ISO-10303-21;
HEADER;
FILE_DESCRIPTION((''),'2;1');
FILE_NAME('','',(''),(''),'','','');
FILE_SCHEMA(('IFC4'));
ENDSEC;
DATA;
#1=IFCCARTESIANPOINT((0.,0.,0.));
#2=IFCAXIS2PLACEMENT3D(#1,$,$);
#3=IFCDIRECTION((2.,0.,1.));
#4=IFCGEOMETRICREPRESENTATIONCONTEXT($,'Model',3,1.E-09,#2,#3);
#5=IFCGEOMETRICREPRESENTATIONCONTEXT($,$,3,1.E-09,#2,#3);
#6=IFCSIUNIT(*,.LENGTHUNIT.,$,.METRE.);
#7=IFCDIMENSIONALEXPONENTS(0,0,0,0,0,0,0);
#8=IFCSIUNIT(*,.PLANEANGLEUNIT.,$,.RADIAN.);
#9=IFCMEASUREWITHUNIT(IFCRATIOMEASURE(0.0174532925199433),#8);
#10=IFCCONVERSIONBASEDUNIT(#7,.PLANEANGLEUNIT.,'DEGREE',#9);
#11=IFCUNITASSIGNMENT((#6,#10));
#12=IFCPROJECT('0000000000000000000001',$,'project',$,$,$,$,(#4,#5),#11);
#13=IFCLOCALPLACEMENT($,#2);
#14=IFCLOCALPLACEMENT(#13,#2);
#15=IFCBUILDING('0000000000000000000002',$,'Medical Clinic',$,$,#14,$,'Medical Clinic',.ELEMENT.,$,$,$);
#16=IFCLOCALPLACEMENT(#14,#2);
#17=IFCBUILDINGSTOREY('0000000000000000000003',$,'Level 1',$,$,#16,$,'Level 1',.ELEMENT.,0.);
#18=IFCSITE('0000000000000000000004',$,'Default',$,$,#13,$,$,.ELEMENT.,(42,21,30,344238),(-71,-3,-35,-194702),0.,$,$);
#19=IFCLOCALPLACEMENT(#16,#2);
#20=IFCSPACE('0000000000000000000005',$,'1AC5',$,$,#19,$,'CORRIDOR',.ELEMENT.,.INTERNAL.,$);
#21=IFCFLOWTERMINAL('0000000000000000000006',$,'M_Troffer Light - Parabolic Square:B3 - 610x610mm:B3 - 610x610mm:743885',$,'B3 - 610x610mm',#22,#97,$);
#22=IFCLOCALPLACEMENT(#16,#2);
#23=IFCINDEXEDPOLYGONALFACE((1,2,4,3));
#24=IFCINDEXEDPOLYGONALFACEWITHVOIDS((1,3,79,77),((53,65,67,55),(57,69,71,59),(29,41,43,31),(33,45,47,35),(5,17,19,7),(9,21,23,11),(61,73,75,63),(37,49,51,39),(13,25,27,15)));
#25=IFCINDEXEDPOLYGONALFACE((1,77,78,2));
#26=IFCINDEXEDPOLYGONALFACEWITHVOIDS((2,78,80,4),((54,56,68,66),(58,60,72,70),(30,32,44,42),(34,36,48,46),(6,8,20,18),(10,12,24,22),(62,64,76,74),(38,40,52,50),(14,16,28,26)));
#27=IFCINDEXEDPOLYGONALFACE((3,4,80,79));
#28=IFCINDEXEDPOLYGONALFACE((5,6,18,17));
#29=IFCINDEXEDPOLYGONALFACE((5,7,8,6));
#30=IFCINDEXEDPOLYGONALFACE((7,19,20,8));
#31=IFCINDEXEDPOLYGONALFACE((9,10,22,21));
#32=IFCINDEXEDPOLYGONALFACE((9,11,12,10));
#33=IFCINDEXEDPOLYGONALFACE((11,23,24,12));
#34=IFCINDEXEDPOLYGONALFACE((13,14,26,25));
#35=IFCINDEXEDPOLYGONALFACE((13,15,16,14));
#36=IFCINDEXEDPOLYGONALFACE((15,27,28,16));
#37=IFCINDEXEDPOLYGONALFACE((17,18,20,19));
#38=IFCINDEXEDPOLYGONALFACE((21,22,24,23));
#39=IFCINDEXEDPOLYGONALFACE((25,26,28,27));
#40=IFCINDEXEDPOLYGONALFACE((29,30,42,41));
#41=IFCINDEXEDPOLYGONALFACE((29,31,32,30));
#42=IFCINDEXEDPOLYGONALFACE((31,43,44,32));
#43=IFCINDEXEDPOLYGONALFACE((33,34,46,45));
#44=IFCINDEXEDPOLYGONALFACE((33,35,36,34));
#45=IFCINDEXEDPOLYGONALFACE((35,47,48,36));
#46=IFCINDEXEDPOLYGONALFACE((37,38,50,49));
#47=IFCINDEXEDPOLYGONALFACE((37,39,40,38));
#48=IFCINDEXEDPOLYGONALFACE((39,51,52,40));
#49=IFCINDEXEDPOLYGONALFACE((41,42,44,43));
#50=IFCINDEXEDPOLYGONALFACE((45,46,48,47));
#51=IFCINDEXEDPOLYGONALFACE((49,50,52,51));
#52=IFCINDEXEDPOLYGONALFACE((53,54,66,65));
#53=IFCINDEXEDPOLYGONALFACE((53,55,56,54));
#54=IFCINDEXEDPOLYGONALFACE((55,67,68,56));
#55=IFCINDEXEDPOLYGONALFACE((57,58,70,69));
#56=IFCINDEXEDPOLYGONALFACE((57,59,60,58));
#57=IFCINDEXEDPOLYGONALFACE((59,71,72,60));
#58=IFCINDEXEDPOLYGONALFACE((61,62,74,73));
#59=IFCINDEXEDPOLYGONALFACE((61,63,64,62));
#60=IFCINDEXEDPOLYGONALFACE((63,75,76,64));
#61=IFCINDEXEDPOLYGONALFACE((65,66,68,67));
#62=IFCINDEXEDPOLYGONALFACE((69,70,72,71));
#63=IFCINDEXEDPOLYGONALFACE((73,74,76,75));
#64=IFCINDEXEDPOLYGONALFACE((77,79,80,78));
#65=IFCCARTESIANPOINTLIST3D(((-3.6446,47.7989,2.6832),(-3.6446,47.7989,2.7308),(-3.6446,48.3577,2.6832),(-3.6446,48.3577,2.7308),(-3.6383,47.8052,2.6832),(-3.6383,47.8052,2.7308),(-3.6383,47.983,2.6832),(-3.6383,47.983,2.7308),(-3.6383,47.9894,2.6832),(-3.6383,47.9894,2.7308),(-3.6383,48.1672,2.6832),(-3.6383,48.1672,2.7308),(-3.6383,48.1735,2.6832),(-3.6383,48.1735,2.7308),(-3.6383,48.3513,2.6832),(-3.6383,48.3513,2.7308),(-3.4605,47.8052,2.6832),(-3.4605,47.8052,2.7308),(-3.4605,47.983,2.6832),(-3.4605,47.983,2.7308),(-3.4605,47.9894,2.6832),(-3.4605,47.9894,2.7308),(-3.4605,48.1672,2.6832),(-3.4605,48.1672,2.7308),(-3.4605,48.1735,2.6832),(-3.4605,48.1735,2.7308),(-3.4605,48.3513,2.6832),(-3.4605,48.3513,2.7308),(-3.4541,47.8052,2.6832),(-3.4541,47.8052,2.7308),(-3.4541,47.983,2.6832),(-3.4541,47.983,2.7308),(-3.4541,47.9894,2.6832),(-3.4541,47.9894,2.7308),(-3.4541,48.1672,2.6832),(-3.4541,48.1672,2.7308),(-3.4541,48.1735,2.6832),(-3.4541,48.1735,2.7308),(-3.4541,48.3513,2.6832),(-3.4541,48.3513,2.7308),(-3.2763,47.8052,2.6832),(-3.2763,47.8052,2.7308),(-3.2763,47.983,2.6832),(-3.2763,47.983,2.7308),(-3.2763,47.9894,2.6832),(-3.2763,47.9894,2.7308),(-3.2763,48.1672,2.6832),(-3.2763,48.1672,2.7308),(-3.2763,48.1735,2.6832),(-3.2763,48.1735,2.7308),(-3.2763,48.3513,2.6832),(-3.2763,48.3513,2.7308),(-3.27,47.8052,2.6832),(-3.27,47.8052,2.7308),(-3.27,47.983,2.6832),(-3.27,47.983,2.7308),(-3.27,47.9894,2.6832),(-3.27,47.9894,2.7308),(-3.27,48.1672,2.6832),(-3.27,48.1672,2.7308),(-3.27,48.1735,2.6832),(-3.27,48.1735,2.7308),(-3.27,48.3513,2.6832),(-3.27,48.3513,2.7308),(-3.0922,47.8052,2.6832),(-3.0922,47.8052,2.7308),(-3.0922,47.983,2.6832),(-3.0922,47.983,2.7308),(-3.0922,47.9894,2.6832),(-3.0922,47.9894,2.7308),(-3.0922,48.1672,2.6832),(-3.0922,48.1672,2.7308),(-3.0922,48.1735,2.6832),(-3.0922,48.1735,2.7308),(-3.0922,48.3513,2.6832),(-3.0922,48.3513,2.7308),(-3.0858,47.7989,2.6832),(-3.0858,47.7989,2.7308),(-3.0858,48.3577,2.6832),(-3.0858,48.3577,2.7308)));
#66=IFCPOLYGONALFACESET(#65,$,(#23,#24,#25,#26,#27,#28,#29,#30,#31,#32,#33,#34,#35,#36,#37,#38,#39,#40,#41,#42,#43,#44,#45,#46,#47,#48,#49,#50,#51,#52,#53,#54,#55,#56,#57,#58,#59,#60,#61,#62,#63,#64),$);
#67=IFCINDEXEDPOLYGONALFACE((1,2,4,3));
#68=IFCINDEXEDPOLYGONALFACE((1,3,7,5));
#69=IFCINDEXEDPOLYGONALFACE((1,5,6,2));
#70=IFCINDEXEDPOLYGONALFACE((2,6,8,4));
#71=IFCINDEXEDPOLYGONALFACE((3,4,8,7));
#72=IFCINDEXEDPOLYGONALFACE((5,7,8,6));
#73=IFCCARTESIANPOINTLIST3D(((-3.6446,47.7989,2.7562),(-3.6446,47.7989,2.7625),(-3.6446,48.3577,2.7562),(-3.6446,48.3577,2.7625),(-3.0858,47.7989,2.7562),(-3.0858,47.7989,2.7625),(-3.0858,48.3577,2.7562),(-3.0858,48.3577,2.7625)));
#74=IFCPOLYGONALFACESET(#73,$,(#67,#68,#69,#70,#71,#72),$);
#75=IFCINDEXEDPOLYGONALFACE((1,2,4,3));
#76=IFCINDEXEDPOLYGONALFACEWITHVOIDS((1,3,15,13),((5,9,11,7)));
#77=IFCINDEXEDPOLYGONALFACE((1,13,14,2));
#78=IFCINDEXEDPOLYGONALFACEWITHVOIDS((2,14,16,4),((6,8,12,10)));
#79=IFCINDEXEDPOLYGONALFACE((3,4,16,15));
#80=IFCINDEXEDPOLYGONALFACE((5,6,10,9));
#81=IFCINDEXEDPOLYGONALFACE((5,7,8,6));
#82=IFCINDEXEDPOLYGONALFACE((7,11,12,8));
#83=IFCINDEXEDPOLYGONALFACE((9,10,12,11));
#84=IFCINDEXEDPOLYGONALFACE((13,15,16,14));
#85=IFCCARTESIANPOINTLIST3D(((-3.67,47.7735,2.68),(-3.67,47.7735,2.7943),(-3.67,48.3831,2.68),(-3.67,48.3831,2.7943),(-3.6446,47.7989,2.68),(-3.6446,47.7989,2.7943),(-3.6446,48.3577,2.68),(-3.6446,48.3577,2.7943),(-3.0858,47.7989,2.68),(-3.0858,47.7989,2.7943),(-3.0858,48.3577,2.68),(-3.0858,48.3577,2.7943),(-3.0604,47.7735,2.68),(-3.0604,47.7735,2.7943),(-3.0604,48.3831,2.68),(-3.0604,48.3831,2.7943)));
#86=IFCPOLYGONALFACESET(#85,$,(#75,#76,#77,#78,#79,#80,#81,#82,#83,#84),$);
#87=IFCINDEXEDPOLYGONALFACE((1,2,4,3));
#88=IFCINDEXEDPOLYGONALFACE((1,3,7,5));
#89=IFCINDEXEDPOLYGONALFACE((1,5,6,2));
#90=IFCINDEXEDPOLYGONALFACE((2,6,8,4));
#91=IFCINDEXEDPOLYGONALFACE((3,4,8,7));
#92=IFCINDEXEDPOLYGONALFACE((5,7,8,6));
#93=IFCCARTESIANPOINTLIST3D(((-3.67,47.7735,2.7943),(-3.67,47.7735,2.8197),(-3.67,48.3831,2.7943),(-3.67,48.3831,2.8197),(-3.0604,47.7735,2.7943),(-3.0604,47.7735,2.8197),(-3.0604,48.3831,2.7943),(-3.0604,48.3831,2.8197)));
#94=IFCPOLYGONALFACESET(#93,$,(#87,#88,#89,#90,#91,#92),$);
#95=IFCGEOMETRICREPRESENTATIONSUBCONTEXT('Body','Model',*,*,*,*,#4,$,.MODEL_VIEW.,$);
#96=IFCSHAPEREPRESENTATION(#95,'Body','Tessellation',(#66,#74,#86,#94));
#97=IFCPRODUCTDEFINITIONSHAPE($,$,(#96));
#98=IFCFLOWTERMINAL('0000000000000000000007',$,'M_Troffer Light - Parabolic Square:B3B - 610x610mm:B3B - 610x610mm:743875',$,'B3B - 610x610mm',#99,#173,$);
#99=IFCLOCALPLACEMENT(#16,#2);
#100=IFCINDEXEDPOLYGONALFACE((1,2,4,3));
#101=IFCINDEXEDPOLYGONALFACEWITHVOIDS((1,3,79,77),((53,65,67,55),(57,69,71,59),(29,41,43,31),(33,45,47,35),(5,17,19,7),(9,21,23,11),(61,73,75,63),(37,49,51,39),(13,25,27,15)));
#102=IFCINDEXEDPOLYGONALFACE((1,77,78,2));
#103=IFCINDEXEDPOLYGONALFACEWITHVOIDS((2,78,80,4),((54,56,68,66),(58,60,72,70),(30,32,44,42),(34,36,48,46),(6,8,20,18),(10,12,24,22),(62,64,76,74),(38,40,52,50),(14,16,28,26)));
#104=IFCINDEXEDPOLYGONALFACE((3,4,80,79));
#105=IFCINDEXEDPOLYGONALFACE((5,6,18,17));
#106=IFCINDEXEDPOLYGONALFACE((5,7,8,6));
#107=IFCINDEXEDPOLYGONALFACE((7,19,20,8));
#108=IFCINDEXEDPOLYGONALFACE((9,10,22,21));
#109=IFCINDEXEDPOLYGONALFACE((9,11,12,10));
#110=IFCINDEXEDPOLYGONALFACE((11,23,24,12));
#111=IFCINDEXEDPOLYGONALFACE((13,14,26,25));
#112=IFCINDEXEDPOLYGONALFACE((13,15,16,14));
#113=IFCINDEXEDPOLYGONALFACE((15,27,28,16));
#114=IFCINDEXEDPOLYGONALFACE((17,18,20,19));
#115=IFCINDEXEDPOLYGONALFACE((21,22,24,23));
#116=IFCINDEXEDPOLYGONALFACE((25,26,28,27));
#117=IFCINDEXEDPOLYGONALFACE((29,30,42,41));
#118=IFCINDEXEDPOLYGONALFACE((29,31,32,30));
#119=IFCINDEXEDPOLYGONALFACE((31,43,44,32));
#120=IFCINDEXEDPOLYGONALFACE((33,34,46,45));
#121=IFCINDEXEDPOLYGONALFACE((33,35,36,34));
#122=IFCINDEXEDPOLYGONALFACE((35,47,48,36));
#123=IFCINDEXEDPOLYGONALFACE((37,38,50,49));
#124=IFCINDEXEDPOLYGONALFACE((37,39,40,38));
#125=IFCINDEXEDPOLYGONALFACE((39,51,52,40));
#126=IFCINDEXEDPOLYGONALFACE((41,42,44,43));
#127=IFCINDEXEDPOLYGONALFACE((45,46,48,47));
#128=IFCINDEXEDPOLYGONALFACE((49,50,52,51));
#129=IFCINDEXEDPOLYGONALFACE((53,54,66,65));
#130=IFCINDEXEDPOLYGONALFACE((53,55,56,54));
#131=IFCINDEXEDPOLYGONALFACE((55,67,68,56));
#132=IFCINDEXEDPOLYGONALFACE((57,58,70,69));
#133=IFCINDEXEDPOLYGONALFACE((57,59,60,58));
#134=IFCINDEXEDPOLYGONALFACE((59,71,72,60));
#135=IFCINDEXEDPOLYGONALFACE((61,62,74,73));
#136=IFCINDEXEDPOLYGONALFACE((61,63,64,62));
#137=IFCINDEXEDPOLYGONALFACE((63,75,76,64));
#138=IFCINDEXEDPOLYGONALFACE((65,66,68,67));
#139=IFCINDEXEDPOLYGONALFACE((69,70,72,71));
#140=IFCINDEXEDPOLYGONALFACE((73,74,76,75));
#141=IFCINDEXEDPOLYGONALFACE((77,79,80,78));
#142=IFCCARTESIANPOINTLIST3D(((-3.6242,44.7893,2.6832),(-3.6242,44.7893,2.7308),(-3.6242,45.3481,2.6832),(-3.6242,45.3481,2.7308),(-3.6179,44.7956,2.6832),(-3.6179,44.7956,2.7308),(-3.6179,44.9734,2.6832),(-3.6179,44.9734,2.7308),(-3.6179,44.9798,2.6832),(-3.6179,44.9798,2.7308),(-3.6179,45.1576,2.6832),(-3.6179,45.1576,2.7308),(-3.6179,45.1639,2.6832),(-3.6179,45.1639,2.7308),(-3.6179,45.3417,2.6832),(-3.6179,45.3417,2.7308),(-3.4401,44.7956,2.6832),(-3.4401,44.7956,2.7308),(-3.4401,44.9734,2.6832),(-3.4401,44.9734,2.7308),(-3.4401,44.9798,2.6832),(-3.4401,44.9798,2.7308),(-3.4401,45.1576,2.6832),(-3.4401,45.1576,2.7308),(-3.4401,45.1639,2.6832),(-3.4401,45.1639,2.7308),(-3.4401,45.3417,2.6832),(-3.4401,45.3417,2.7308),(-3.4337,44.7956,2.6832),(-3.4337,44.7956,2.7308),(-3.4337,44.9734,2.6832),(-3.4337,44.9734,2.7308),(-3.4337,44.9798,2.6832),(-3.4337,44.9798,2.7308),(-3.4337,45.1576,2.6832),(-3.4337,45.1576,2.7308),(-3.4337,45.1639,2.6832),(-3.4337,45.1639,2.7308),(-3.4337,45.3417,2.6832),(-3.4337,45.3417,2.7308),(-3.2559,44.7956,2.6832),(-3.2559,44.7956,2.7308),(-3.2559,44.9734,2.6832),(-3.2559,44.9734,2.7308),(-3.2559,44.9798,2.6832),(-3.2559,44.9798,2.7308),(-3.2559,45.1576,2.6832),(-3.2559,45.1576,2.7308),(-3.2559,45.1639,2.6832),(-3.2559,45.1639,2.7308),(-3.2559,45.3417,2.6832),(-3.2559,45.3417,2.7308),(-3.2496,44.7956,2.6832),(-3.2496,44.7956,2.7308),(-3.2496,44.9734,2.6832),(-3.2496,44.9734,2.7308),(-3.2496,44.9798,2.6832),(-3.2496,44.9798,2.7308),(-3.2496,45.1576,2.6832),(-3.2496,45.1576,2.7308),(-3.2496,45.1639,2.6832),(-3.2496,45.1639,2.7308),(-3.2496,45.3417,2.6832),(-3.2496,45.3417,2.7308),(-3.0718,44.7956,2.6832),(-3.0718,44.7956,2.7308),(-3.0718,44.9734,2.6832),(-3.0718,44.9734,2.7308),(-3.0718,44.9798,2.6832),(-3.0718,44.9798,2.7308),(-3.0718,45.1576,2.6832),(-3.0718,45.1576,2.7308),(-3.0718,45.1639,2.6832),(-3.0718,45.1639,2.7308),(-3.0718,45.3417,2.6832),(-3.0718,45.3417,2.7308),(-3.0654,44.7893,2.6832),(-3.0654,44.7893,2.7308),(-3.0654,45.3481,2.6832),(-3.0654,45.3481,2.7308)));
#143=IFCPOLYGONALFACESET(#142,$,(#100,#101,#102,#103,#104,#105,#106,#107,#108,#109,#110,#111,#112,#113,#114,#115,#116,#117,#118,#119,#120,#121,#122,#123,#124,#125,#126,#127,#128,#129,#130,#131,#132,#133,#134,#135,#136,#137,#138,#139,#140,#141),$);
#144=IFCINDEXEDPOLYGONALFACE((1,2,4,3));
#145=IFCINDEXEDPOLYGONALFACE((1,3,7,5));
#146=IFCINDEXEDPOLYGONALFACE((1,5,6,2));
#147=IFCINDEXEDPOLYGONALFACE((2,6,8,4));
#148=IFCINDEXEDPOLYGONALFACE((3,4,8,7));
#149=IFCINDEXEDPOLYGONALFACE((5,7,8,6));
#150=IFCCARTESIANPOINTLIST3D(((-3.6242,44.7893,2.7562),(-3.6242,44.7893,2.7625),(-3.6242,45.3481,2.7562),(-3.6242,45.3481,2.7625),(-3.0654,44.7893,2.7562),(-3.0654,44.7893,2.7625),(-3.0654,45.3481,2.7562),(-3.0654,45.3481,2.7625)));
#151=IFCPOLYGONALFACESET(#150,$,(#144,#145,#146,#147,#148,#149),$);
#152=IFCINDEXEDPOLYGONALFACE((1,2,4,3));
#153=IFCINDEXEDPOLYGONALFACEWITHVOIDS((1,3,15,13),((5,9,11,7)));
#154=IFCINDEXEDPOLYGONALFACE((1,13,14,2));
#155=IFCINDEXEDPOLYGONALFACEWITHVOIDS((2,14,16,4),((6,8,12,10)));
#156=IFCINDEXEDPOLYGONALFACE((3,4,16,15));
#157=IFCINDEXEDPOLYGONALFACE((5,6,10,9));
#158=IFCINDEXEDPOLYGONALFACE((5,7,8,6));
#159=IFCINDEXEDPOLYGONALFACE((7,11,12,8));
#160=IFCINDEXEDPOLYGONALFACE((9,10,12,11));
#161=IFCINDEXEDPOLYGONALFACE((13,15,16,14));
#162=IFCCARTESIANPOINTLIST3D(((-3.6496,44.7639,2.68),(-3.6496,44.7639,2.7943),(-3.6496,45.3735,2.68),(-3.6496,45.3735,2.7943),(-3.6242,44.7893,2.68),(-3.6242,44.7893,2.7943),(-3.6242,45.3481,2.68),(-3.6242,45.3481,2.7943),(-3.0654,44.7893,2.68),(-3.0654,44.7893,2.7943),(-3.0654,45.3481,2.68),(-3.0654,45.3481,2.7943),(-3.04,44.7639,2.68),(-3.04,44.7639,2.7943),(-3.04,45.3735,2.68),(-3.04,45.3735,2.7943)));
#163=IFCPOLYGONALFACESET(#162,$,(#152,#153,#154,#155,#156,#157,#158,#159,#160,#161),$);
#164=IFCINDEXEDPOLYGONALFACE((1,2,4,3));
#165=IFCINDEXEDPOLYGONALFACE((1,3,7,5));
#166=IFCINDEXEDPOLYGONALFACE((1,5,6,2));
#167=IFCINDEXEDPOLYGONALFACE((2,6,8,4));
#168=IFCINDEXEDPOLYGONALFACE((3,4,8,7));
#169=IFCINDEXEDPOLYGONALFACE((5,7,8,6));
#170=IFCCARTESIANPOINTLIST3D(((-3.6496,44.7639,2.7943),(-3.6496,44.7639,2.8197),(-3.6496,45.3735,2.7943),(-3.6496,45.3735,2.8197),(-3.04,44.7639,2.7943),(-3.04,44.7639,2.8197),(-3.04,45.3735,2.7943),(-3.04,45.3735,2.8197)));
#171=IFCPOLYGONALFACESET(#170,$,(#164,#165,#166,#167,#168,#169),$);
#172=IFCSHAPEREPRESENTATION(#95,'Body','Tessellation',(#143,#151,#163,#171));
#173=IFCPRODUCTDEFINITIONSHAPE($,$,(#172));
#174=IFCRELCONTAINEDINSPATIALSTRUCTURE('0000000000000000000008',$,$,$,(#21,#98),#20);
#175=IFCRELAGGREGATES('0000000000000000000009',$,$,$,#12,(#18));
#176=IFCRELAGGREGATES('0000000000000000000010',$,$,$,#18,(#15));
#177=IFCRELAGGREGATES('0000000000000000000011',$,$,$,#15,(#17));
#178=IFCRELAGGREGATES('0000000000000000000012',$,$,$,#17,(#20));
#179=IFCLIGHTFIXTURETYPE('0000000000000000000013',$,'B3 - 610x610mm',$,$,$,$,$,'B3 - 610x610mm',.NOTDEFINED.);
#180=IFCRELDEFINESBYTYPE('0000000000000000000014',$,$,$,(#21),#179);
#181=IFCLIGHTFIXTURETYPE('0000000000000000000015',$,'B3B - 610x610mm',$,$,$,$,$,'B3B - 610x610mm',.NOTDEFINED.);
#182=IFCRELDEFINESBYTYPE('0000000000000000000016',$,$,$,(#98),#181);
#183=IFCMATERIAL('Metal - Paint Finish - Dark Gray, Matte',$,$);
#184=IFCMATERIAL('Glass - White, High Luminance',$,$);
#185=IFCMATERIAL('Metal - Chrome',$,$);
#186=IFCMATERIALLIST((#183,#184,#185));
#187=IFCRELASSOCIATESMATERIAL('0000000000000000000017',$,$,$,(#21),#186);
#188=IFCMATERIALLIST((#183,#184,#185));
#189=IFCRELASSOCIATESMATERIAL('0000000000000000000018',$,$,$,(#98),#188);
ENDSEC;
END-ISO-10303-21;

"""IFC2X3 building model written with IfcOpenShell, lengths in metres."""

from ifc_helpers import new_model, entity, si_unit, converted_unit, direction, frame, origin, origin_2d_with_axis, place, context, subcontext, project, spatial, polyline, rectangle, outline, extrude, source, transform, mapped, material, material_list, type_object, type_shapes, element, save


model = new_model("IFC2X3")

# Units and contexts
model_context = context("Model", 3, precision=1e-09, world=origin(), true_north=direction((2.0, 0.0, 1.0)))
context_of_model = context(None, 3, precision=1e-09, world=origin(), true_north=direction((2.0, 0.0, 1.0)))
body_context = subcontext(model_context, "Body", "Model", "MODEL_VIEW")
ifc_project = project(units=[si_unit("LENGTHUNIT", "METRE"), converted_unit("PLANEANGLEUNIT", "DEGREE", entity("IfcRatioMeasure", 0.0174532925199433), si_unit("PLANEANGLEUNIT", "RADIAN"), dimensions=[0, 0, 0, 0, 0, 0, 0])], contexts=[model_context, context_of_model])

# Site, building, storey, space
site_placement = place(None, origin())
site = spatial("IfcSite", under=ifc_project, at=site_placement, Name="Default", CompositionType="ELEMENT", RefLatitude=(42, 21, 30, 344238), RefLongitude=(-71, -3, -35, -194702), RefElevation=0.0)
building_placement = place(site_placement, origin())
building = spatial("IfcBuilding", under=site, at=building_placement, Name="Medical Clinic", LongName="Medical Clinic", CompositionType="ELEMENT")
storey_placement = place(building_placement, origin())
storey = spatial("IfcBuildingStorey", under=building, at=storey_placement, Name="Level 1", LongName="Level 1", CompositionType="ELEMENT", Elevation=0.0)
space_1_placement = place(storey_placement, origin())
space_1 = spatial("IfcSpace", under=storey, at=space_1_placement, Name="1AC5", LongName="CORRIDOR", CompositionType="ELEMENT", InteriorOrExteriorSpace="INTERNAL")

# Flow terminals
ifc_material_1 = material(Name="Metal - Paint Finish - Dark Gray, Matte")
ifc_material_2 = material(Name="Glass - White, High Luminance")
ifc_material_3 = material(Name="Metal - Chrome")
ifc_material_list_1 = material_list([ifc_material_1, ifc_material_2, ifc_material_3])
light_fixture_type_1 = type_object("IfcLightFixtureType", Name="B3 - 610x610mm", ElementType="B3 - 610x610mm", PredefinedType="NOTDEFINED")
shared_shape_1 = source(origin(), body_context, "Body", "SweptSolid", [
    extrude(outline(polyline([(-0.2794, -0.2794), (0.2794, -0.2794), (0.2794, 0.2794), (-0.2794, 0.2794), (-0.2794, -0.2794)]), holes=[polyline([(-0.0952, 0.0953), (-0.273, 0.0953), (-0.273, 0.2731), (-0.0952, 0.2731), (-0.0952, 0.0953)]), polyline([(0.2731, 0.0953), (0.0953, 0.0953), (0.0953, 0.2731), (0.2731, 0.2731), (0.2731, 0.0953)]), polyline([(-0.0889, 0.2731), (0.0889, 0.2731), (0.0889, 0.0953), (-0.0889, 0.0953), (-0.0889, 0.2731)]), polyline([(0.2731, -0.273), (0.0953, -0.273), (0.0953, -0.0952), (0.2731, -0.0952), (0.2731, -0.273)]), polyline([(0.0889, -0.273), (-0.0889, -0.273), (-0.0889, -0.0952), (0.0889, -0.0952), (0.0889, -0.273)]), polyline([(-0.0952, -0.273), (-0.273, -0.273), (-0.273, -0.0952), (-0.0952, -0.0952), (-0.0952, -0.273)]), polyline([(-0.0952, -0.0889), (-0.273, -0.0889), (-0.273, 0.0889), (-0.0952, 0.0889), (-0.0952, -0.0889)]), polyline([(0.0889, -0.0889), (-0.0889, -0.0889), (-0.0889, 0.0889), (0.0889, 0.0889), (0.0889, -0.0889)]), polyline([(0.2731, -0.0889), (0.0953, -0.0889), (0.0953, 0.0889), (0.2731, 0.0889), (0.2731, -0.0889)])]), frame((0.0, -0.3048, -0.0508), z_axis=(0.0, 0.0, 1.0), x_axis=(-1.0, 0.0, 0.0)), (0.0, 0.0, 1.0), 0.0476),
    extrude(rectangle(XDim=0.5588, YDim=0.5588, at=origin_2d_with_axis()), frame((0.0, -0.3048, -0.0825), z_axis=(0.0, 0.0, 1.0), x_axis=(-1.0, 0.0, 0.0)), (0.0, 0.0, 1.0), 0.0064),
    extrude(outline(polyline([(-0.3048, -0.3048), (0.3048, -0.3048), (0.3048, 0.3048), (-0.3048, 0.3048), (-0.3048, -0.3048)]), holes=[polyline([(0.2794, 0.2794), (0.2794, -0.2794), (-0.2794, -0.2794), (-0.2794, 0.2794), (0.2794, 0.2794)])]), frame((0.0, -0.3048, -0.1143)), (0.0, 0.0, 1.0), 0.1143),
    extrude(rectangle(XDim=0.6096, YDim=0.6096, at=origin_2d_with_axis()), frame((0.0, -0.3048, -0.1397), z_axis=(0.0, 0.0, 1.0), x_axis=(-1.0, 0.0, 0.0)), (0.0, 0.0, 1.0), 0.0254),
])
type_shapes(light_fixture_type_1, [shared_shape_1])
flow_terminal_1_placement = place(space_1_placement, frame((-3.3652, 47.7735, 2.68), z_axis=(0.0, 0.0, -1.0), x_axis=(1.0, 0.0, 0.0)))
element("IfcFlowTerminal", 1, at=flow_terminal_1_placement, inside=space_1, type_object=light_fixture_type_1, material=ifc_material_list_1, Name="M_Troffer Light - Parabolic Square:B3 - 610x610mm:B3 - 610x610mm:743885", ObjectType="B3 - 610x610mm", context=body_context, shape_type="MappedRepresentation", body=[
    mapped(shared_shape_1, transform((0.0, 0.0, 0.0), scale=1.0)),
])
ifc_material_list_2 = material_list([ifc_material_1, ifc_material_2, ifc_material_3])
light_fixture_type_2 = type_object("IfcLightFixtureType", Name="B3B - 610x610mm", ElementType="B3B - 610x610mm", PredefinedType="NOTDEFINED")
shared_shape_2 = source(origin(), body_context, "Body", "SweptSolid", [
    extrude(outline(polyline([(-0.2794, -0.2794), (0.2794, -0.2794), (0.2794, 0.2794), (-0.2794, 0.2794), (-0.2794, -0.2794)]), holes=[polyline([(-0.0952, 0.0953), (-0.273, 0.0953), (-0.273, 0.2731), (-0.0952, 0.2731), (-0.0952, 0.0953)]), polyline([(0.2731, 0.0953), (0.0953, 0.0953), (0.0953, 0.2731), (0.2731, 0.2731), (0.2731, 0.0953)]), polyline([(-0.0889, 0.2731), (0.0889, 0.2731), (0.0889, 0.0953), (-0.0889, 0.0953), (-0.0889, 0.2731)]), polyline([(0.2731, -0.273), (0.0953, -0.273), (0.0953, -0.0952), (0.2731, -0.0952), (0.2731, -0.273)]), polyline([(0.0889, -0.273), (-0.0889, -0.273), (-0.0889, -0.0952), (0.0889, -0.0952), (0.0889, -0.273)]), polyline([(-0.0952, -0.273), (-0.273, -0.273), (-0.273, -0.0952), (-0.0952, -0.0952), (-0.0952, -0.273)]), polyline([(-0.0952, -0.0889), (-0.273, -0.0889), (-0.273, 0.0889), (-0.0952, 0.0889), (-0.0952, -0.0889)]), polyline([(0.0889, -0.0889), (-0.0889, -0.0889), (-0.0889, 0.0889), (0.0889, 0.0889), (0.0889, -0.0889)]), polyline([(0.2731, -0.0889), (0.0953, -0.0889), (0.0953, 0.0889), (0.2731, 0.0889), (0.2731, -0.0889)])]), frame((0.0, -0.3048, -0.0508), z_axis=(0.0, 0.0, 1.0), x_axis=(-1.0, 0.0, 0.0)), (0.0, 0.0, 1.0), 0.0476),
    extrude(rectangle(XDim=0.5588, YDim=0.5588, at=origin_2d_with_axis()), frame((0.0, -0.3048, -0.0825), z_axis=(0.0, 0.0, 1.0), x_axis=(-1.0, 0.0, 0.0)), (0.0, 0.0, 1.0), 0.0064),
    extrude(outline(polyline([(-0.3048, -0.3048), (0.3048, -0.3048), (0.3048, 0.3048), (-0.3048, 0.3048), (-0.3048, -0.3048)]), holes=[polyline([(0.2794, 0.2794), (0.2794, -0.2794), (-0.2794, -0.2794), (-0.2794, 0.2794), (0.2794, 0.2794)])]), frame((0.0, -0.3048, -0.1143)), (0.0, 0.0, 1.0), 0.1143),
    extrude(rectangle(XDim=0.6096, YDim=0.6096, at=origin_2d_with_axis()), frame((0.0, -0.3048, -0.1397), z_axis=(0.0, 0.0, 1.0), x_axis=(-1.0, 0.0, 0.0)), (0.0, 0.0, 1.0), 0.0254),
])
type_shapes(light_fixture_type_2, [shared_shape_2])
flow_terminal_2_placement = place(space_1_placement, frame((-3.3448, 44.7639, 2.68), z_axis=(0.0, 0.0, -1.0), x_axis=(1.0, 0.0, 0.0)))
element("IfcFlowTerminal", 2, at=flow_terminal_2_placement, inside=space_1, type_object=light_fixture_type_2, material=ifc_material_list_2, Name="M_Troffer Light - Parabolic Square:B3B - 610x610mm:B3B - 610x610mm:743875", ObjectType="B3B - 610x610mm", context=body_context, shape_type="MappedRepresentation", body=[
    mapped(shared_shape_2, transform((0.0, 0.0, 0.0), scale=1.0)),
])

save(model, "model.ifc")
